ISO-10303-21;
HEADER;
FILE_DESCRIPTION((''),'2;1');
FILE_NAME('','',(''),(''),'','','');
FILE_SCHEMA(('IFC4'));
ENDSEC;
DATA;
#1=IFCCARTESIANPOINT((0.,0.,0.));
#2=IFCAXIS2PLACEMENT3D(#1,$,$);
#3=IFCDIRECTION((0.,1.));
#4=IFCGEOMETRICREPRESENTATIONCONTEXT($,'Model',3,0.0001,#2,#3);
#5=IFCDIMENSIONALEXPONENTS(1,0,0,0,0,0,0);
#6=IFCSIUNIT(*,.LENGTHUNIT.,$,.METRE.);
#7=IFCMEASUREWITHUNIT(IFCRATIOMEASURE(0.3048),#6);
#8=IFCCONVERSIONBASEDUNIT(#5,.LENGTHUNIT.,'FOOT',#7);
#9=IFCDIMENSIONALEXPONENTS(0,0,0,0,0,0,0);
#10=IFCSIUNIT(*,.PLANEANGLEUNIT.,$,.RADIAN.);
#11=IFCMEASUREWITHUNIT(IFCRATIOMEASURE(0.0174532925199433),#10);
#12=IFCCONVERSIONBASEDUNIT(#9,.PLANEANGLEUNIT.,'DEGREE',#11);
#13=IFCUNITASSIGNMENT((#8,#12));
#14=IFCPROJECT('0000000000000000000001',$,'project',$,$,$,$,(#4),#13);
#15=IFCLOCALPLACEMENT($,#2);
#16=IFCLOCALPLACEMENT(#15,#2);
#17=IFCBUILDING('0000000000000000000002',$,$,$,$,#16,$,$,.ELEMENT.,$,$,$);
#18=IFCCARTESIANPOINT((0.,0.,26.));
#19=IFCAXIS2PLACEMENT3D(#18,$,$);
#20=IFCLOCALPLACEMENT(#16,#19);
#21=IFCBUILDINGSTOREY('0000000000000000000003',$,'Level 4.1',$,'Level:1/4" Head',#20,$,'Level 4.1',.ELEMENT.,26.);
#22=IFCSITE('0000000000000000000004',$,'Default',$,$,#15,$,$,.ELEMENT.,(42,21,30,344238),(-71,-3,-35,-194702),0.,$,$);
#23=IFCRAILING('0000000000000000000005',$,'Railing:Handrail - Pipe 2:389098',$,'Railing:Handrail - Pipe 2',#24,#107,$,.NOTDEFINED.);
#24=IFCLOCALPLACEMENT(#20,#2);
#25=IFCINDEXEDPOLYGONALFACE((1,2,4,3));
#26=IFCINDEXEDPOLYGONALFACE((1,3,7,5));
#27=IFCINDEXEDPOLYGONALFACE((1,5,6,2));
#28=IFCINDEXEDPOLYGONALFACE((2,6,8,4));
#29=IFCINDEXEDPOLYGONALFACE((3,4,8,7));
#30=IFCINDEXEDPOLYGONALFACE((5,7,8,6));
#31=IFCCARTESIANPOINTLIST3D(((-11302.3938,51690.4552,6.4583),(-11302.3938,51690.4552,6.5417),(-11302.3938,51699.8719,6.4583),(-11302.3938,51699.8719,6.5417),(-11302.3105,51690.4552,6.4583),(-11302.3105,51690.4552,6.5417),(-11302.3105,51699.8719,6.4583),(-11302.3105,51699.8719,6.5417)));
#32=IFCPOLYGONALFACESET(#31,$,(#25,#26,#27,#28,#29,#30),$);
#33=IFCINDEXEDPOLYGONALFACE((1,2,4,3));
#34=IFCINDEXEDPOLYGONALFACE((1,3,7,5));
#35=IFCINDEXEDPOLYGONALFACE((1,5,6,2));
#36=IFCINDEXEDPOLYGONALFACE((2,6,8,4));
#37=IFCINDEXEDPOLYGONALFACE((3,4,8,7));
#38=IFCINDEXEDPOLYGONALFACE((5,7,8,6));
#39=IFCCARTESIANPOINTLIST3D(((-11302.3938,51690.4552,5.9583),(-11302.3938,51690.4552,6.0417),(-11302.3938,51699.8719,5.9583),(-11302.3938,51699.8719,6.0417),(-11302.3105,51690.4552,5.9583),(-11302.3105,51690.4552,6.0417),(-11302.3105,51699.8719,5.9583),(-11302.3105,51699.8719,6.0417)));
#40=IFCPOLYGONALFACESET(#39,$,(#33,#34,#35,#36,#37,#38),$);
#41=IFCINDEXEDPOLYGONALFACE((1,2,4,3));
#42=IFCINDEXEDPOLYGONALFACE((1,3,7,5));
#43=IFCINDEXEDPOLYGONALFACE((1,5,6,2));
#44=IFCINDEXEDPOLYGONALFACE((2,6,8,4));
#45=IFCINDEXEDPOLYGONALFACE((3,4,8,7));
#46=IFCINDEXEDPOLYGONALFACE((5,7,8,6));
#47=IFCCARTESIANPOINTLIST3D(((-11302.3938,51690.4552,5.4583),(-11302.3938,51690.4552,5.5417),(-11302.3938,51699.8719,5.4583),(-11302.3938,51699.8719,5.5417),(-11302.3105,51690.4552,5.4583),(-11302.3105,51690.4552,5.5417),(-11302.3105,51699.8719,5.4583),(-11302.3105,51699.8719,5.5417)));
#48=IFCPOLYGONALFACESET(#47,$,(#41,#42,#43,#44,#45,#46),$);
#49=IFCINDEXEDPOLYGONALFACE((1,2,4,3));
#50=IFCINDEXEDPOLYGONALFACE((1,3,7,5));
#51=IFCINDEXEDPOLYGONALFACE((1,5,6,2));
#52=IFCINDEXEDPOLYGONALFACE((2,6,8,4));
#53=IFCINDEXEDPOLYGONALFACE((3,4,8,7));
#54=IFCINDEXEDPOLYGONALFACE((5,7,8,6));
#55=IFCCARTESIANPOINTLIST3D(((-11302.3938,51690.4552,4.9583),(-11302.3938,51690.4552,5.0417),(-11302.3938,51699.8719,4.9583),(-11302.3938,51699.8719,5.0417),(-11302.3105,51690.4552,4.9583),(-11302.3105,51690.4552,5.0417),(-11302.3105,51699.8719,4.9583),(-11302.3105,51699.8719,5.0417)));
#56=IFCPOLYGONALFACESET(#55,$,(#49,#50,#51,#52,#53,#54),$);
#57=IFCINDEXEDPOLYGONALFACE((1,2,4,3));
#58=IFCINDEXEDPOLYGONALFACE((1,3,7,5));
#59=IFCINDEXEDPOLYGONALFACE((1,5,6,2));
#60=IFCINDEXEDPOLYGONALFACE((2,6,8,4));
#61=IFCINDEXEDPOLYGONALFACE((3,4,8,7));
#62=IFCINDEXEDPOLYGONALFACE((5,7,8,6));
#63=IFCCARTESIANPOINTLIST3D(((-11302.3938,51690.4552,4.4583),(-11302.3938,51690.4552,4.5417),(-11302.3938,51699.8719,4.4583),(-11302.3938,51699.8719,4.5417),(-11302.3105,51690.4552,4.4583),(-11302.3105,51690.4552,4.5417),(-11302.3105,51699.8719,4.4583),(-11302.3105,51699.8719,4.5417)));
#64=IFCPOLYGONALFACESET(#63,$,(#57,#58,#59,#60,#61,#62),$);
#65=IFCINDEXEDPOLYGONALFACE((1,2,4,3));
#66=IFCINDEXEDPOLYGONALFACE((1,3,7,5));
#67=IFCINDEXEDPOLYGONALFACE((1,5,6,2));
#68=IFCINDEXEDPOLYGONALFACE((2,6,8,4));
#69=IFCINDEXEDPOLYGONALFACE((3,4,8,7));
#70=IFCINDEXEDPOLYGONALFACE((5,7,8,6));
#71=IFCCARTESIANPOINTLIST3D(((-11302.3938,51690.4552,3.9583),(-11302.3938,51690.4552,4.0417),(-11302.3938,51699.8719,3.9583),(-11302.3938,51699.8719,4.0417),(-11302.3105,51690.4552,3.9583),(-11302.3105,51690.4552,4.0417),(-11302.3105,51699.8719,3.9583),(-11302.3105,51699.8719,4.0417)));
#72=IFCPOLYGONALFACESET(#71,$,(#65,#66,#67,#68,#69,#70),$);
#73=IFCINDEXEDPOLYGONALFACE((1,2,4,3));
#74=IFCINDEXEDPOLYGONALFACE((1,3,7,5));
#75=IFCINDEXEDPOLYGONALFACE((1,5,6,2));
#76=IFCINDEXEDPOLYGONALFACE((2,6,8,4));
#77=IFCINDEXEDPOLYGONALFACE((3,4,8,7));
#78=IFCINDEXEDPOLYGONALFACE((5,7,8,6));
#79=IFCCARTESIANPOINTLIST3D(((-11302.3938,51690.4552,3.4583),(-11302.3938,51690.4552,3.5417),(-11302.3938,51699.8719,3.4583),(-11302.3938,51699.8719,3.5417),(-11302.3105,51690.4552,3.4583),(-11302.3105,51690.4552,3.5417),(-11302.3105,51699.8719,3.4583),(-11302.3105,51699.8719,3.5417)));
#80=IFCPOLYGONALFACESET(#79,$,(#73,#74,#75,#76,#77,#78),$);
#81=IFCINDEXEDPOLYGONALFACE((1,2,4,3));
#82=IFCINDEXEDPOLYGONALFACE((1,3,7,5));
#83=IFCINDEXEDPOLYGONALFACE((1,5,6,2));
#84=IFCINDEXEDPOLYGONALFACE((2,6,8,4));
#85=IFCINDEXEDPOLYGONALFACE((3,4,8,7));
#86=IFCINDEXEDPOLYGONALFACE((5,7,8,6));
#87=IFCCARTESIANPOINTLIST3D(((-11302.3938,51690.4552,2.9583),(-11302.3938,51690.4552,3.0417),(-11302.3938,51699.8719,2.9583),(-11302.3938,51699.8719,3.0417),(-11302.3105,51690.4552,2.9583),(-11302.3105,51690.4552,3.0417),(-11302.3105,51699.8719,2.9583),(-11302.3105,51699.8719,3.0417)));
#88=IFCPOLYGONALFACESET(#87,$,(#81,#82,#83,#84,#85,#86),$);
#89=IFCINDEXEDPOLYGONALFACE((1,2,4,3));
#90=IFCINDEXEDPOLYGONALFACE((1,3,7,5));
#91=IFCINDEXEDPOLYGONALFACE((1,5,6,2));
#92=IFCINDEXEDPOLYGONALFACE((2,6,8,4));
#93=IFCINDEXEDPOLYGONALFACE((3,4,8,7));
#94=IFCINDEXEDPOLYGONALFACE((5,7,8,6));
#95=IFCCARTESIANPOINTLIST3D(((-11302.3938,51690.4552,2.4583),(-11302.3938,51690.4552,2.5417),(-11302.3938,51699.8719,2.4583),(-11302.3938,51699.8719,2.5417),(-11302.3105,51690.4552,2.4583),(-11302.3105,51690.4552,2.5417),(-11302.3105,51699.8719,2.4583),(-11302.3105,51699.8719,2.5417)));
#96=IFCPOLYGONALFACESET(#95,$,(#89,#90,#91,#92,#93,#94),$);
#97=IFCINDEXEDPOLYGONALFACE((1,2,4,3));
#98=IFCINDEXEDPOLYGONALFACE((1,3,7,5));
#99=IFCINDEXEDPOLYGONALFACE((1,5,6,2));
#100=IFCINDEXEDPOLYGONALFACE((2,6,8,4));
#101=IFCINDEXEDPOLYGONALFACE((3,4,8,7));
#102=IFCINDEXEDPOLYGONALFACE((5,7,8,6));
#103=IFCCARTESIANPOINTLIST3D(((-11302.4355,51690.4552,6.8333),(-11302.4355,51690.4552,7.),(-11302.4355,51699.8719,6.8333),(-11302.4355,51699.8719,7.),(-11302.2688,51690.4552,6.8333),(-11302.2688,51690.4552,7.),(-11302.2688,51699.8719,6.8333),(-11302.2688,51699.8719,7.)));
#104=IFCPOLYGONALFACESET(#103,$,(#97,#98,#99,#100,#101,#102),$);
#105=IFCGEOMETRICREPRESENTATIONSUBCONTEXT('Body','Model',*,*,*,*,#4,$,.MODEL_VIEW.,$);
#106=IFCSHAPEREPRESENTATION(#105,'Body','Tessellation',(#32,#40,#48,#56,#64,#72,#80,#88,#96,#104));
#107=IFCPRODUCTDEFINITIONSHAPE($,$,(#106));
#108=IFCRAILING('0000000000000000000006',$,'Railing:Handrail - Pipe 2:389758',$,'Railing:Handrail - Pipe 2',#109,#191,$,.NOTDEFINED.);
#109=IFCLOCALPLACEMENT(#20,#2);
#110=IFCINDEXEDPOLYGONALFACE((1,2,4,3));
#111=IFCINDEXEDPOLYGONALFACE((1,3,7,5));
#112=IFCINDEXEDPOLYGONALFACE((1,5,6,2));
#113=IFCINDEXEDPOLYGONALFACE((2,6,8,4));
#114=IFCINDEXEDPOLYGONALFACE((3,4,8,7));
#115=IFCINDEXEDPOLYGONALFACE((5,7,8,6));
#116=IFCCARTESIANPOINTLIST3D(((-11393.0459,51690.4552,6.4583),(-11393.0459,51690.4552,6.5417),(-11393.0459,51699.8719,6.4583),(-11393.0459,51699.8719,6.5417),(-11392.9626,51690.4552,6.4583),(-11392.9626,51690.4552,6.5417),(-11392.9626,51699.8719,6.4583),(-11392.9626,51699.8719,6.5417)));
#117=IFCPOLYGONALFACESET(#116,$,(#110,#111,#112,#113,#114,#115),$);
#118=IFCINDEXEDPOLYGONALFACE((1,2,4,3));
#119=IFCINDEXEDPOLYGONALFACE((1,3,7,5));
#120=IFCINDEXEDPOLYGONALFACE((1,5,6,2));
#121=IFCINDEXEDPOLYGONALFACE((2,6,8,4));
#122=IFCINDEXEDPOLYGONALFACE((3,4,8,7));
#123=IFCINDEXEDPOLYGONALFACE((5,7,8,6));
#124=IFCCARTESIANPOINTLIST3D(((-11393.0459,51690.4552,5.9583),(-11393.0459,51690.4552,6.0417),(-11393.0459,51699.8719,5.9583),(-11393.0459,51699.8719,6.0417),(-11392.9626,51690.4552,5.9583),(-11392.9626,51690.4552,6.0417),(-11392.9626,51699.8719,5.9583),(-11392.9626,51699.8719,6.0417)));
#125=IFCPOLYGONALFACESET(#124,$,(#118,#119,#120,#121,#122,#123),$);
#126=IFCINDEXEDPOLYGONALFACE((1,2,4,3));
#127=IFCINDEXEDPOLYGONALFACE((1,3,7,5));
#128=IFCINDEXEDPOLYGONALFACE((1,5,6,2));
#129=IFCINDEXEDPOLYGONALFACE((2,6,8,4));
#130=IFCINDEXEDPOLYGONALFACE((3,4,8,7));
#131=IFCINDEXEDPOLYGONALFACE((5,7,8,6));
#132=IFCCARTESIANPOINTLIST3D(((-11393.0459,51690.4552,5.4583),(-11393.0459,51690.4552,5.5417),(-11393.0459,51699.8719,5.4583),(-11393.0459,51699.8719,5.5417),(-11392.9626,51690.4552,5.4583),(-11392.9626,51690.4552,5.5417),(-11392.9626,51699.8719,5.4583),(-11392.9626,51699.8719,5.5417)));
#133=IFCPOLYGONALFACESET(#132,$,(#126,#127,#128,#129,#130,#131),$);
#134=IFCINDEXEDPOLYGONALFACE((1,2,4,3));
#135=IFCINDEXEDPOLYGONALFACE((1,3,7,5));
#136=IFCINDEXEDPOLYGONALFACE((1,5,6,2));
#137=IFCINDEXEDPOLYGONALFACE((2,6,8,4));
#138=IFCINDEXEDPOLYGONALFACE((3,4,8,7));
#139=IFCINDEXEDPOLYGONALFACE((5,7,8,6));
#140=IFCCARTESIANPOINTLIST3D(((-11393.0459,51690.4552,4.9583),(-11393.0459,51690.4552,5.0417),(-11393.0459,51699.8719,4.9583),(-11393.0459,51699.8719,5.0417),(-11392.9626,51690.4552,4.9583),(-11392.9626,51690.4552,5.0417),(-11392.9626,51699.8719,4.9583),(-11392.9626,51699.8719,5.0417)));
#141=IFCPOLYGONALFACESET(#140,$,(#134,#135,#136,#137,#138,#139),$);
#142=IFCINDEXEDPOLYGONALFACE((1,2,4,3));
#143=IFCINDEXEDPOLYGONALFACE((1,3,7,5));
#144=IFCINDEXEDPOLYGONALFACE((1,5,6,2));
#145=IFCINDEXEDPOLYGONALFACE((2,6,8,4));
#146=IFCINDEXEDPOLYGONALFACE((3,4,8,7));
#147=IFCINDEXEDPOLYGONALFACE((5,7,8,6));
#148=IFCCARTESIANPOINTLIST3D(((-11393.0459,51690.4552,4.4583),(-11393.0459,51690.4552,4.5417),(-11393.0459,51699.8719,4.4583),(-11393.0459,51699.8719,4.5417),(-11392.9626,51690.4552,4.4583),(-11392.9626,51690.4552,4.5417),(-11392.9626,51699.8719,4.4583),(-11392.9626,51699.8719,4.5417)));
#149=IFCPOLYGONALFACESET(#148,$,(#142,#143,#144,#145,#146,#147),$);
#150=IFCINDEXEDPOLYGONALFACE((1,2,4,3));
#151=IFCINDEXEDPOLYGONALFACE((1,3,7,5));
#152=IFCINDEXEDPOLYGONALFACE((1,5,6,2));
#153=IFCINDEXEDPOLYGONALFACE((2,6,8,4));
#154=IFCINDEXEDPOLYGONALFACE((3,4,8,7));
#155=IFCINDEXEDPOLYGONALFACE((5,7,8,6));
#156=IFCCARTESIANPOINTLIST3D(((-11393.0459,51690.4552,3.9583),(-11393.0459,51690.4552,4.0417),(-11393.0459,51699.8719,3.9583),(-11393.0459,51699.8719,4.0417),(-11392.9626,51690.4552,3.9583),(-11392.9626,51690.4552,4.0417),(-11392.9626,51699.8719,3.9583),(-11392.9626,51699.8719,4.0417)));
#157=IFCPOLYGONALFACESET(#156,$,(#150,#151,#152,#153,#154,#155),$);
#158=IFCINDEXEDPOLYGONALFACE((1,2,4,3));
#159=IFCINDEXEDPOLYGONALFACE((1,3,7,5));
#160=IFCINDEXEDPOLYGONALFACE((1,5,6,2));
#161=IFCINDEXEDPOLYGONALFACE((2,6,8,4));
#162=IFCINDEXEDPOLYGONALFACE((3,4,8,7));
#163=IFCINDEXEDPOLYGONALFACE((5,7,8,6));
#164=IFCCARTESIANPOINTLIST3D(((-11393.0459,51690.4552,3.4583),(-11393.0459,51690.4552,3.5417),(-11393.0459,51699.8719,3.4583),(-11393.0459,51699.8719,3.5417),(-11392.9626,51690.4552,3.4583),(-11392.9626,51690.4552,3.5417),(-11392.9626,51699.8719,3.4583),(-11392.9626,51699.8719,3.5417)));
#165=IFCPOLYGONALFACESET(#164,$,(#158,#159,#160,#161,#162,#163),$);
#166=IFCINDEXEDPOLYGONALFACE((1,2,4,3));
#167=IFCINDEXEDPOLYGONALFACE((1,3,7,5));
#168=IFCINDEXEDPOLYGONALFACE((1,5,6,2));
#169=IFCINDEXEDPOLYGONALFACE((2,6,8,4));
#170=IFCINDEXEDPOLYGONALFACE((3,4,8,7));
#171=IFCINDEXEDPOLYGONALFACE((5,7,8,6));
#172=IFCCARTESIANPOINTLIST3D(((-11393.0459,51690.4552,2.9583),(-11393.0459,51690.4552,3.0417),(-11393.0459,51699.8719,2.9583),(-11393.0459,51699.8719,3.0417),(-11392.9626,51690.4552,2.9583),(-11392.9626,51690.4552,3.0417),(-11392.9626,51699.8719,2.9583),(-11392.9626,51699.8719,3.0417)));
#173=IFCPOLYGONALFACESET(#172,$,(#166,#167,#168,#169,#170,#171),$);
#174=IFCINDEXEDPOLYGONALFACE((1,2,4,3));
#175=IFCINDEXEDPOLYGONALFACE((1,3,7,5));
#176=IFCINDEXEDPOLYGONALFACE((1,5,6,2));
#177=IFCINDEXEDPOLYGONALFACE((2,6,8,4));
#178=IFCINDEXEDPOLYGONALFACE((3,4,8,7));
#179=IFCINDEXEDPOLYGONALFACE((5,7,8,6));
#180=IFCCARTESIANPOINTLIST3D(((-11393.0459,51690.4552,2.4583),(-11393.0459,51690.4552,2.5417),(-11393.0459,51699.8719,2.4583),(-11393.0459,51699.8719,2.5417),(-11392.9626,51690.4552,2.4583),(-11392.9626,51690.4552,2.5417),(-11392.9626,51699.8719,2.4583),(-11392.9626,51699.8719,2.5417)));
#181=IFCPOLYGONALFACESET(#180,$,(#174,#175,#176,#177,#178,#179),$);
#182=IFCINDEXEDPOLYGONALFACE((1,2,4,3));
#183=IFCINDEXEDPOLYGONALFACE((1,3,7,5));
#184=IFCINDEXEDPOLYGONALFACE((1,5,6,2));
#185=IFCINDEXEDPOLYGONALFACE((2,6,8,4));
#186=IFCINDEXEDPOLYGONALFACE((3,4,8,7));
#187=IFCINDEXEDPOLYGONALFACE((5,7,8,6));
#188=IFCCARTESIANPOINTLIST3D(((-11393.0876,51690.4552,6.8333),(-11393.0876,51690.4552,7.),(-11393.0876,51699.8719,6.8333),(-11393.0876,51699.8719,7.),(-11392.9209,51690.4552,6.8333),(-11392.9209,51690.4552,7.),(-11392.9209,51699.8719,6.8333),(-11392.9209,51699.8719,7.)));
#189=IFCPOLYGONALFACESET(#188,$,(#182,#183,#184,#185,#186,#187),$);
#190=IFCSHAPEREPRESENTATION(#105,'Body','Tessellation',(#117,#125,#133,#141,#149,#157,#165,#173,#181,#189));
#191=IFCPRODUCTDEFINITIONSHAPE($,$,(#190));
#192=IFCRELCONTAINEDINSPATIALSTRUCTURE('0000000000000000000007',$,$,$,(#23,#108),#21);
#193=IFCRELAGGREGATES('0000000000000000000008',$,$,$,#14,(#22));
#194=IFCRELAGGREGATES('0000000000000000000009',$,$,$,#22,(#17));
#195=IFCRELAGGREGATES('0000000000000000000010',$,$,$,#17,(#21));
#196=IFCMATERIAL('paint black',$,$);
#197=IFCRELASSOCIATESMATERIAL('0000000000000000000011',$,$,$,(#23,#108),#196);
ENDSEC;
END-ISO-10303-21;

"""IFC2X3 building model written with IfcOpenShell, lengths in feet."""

from ifc_helpers import new_model, entity, si_unit, converted_unit, direction, frame, frame_2d, origin, place, context, subcontext, project, spatial, rectangle, extrude, material, element, save


model = new_model("IFC2X3")

# Units and contexts
model_context = context("Model", 3, precision=0.0001, world=origin(), true_north=direction((0.0, 1.0)))
body_context = subcontext(model_context, "Body", "Model", "MODEL_VIEW")
ifc_project = project(units=[converted_unit("LENGTHUNIT", "FOOT", entity("IfcRatioMeasure", 0.3048), si_unit("LENGTHUNIT", "METRE"), dimensions=[1, 0, 0, 0, 0, 0, 0]), converted_unit("PLANEANGLEUNIT", "DEGREE", entity("IfcRatioMeasure", 0.0174532925199433), si_unit("PLANEANGLEUNIT", "RADIAN"), dimensions=[0, 0, 0, 0, 0, 0, 0])], contexts=[model_context])

# Site, building, storey
site_placement = place(None, origin())
site = spatial("IfcSite", under=ifc_project, at=site_placement, Name="Default", CompositionType="ELEMENT", RefLatitude=(42, 21, 30, 344238), RefLongitude=(-71, -3, -35, -194702), RefElevation=0.0)
building_placement = place(site_placement, origin())
building = spatial("IfcBuilding", under=site, at=building_placement, CompositionType="ELEMENT")
storey_placement = place(building_placement, frame((0.0, 0.0, 26.0)))
storey = spatial("IfcBuildingStorey", under=building, at=storey_placement, Name="Level 4.1", ObjectType="Level:1/4\" Head", LongName="Level 4.1", CompositionType="ELEMENT", Elevation=26.0)

# Railings
ifc_material_1 = material(Name="paint black")
railing_1_placement = place(storey_placement, origin())
element("IfcRailing", 1, at=railing_1_placement, inside=storey, material=ifc_material_1, Name="Railing:Handrail - Pipe 2:389098", ObjectType="Railing:Handrail - Pipe 2", PredefinedType="NOTDEFINED", context=body_context, shape_type="SweptSolid", body=[
    extrude(rectangle(XDim=9.4167, YDim=0.0833, at=frame_2d((0.0, 0.0), x_axis=(1.0, 0.0))), frame((-11302.3522, 51695.1636, 6.4583), z_axis=(0.0, 0.0, 1.0), x_axis=(0.0, 1.0, 0.0)), (0.0, 0.0, 1.0), 0.0833),
    extrude(rectangle(XDim=9.4167, YDim=0.0833, at=frame_2d((0.0, 0.0), x_axis=(1.0, 0.0))), frame((-11302.3522, 51695.1636, 5.9583), z_axis=(0.0, 0.0, 1.0), x_axis=(0.0, 1.0, 0.0)), (0.0, 0.0, 1.0), 0.0833),
    extrude(rectangle(XDim=9.4167, YDim=0.0833, at=frame_2d((0.0, 0.0), x_axis=(1.0, 0.0))), frame((-11302.3522, 51695.1636, 5.4583), z_axis=(0.0, 0.0, 1.0), x_axis=(0.0, 1.0, 0.0)), (0.0, 0.0, 1.0), 0.0833),
    extrude(rectangle(XDim=9.4167, YDim=0.0833, at=frame_2d((0.0, 0.0), x_axis=(1.0, 0.0))), frame((-11302.3522, 51695.1636, 4.9583), z_axis=(0.0, 0.0, 1.0), x_axis=(0.0, 1.0, 0.0)), (0.0, 0.0, 1.0), 0.0833),
    extrude(rectangle(XDim=9.4167, YDim=0.0833, at=frame_2d((0.0, 0.0), x_axis=(1.0, 0.0))), frame((-11302.3522, 51695.1636, 4.4583), z_axis=(0.0, 0.0, 1.0), x_axis=(0.0, 1.0, 0.0)), (0.0, 0.0, 1.0), 0.0833),
    extrude(rectangle(XDim=9.4167, YDim=0.0833, at=frame_2d((0.0, 0.0), x_axis=(1.0, 0.0))), frame((-11302.3522, 51695.1636, 3.9583), z_axis=(0.0, 0.0, 1.0), x_axis=(0.0, 1.0, 0.0)), (0.0, 0.0, 1.0), 0.0833),
    extrude(rectangle(XDim=9.4167, YDim=0.0833, at=frame_2d((0.0, 0.0), x_axis=(1.0, 0.0))), frame((-11302.3522, 51695.1636, 3.4583), z_axis=(0.0, 0.0, 1.0), x_axis=(0.0, 1.0, 0.0)), (0.0, 0.0, 1.0), 0.0833),
    extrude(rectangle(XDim=9.4167, YDim=0.0833, at=frame_2d((0.0, 0.0), x_axis=(1.0, 0.0))), frame((-11302.3522, 51695.1636, 2.9583), z_axis=(0.0, 0.0, 1.0), x_axis=(0.0, 1.0, 0.0)), (0.0, 0.0, 1.0), 0.0833),
    extrude(rectangle(XDim=9.4167, YDim=0.0833, at=frame_2d((0.0, 0.0), x_axis=(1.0, 0.0))), frame((-11302.3522, 51695.1636, 2.4583), z_axis=(0.0, 0.0, 1.0), x_axis=(0.0, 1.0, 0.0)), (0.0, 0.0, 1.0), 0.0833),
    extrude(rectangle(XDim=9.4167, YDim=0.1667, at=frame_2d((0.0, 0.0), x_axis=(1.0, 0.0))), frame((-11302.3522, 51695.1636, 6.8333), z_axis=(0.0, 0.0, 1.0), x_axis=(0.0, 1.0, 0.0)), (0.0, 0.0, 1.0), 0.1667),
])
railing_2_placement = place(storey_placement, origin())
element("IfcRailing", 2, at=railing_2_placement, inside=storey, material=ifc_material_1, Name="Railing:Handrail - Pipe 2:389758", ObjectType="Railing:Handrail - Pipe 2", PredefinedType="NOTDEFINED", context=body_context, shape_type="SweptSolid", body=[
    extrude(rectangle(XDim=9.4167, YDim=0.0833, at=frame_2d((0.0, 0.0), x_axis=(1.0, 0.0))), frame((-11393.0042, 51695.1636, 6.4583), z_axis=(0.0, 0.0, 1.0), x_axis=(0.0, 1.0, 0.0)), (0.0, 0.0, 1.0), 0.0833),
    extrude(rectangle(XDim=9.4167, YDim=0.0833, at=frame_2d((0.0, 0.0), x_axis=(1.0, 0.0))), frame((-11393.0042, 51695.1636, 5.9583), z_axis=(0.0, 0.0, 1.0), x_axis=(0.0, 1.0, 0.0)), (0.0, 0.0, 1.0), 0.0833),
    extrude(rectangle(XDim=9.4167, YDim=0.0833, at=frame_2d((0.0, 0.0), x_axis=(1.0, 0.0))), frame((-11393.0042, 51695.1636, 5.4583), z_axis=(0.0, 0.0, 1.0), x_axis=(0.0, 1.0, 0.0)), (0.0, 0.0, 1.0), 0.0833),
    extrude(rectangle(XDim=9.4167, YDim=0.0833, at=frame_2d((0.0, 0.0), x_axis=(1.0, 0.0))), frame((-11393.0042, 51695.1636, 4.9583), z_axis=(0.0, 0.0, 1.0), x_axis=(0.0, 1.0, 0.0)), (0.0, 0.0, 1.0), 0.0833),
    extrude(rectangle(XDim=9.4167, YDim=0.0833, at=frame_2d((0.0, 0.0), x_axis=(1.0, 0.0))), frame((-11393.0042, 51695.1636, 4.4583), z_axis=(0.0, 0.0, 1.0), x_axis=(0.0, 1.0, 0.0)), (0.0, 0.0, 1.0), 0.0833),
    extrude(rectangle(XDim=9.4167, YDim=0.0833, at=frame_2d((0.0, 0.0), x_axis=(1.0, 0.0))), frame((-11393.0042, 51695.1636, 3.9583), z_axis=(0.0, 0.0, 1.0), x_axis=(0.0, 1.0, 0.0)), (0.0, 0.0, 1.0), 0.0833),
    extrude(rectangle(XDim=9.4167, YDim=0.0833, at=frame_2d((0.0, 0.0), x_axis=(1.0, 0.0))), frame((-11393.0042, 51695.1636, 3.4583), z_axis=(0.0, 0.0, 1.0), x_axis=(0.0, 1.0, 0.0)), (0.0, 0.0, 1.0), 0.0833),
    extrude(rectangle(XDim=9.4167, YDim=0.0833, at=frame_2d((0.0, 0.0), x_axis=(1.0, 0.0))), frame((-11393.0042, 51695.1636, 2.9583), z_axis=(0.0, 0.0, 1.0), x_axis=(0.0, 1.0, 0.0)), (0.0, 0.0, 1.0), 0.0833),
    extrude(rectangle(XDim=9.4167, YDim=0.0833, at=frame_2d((0.0, 0.0), x_axis=(1.0, 0.0))), frame((-11393.0042, 51695.1636, 2.4583), z_axis=(0.0, 0.0, 1.0), x_axis=(0.0, 1.0, 0.0)), (0.0, 0.0, 1.0), 0.0833),
    extrude(rectangle(XDim=9.4167, YDim=0.1667, at=frame_2d((0.0, 0.0), x_axis=(1.0, 0.0))), frame((-11393.0042, 51695.1636, 6.8333), z_axis=(0.0, 0.0, 1.0), x_axis=(0.0, 1.0, 0.0)), (0.0, 0.0, 1.0), 0.1667),
])

save(model, "model.ifc")
